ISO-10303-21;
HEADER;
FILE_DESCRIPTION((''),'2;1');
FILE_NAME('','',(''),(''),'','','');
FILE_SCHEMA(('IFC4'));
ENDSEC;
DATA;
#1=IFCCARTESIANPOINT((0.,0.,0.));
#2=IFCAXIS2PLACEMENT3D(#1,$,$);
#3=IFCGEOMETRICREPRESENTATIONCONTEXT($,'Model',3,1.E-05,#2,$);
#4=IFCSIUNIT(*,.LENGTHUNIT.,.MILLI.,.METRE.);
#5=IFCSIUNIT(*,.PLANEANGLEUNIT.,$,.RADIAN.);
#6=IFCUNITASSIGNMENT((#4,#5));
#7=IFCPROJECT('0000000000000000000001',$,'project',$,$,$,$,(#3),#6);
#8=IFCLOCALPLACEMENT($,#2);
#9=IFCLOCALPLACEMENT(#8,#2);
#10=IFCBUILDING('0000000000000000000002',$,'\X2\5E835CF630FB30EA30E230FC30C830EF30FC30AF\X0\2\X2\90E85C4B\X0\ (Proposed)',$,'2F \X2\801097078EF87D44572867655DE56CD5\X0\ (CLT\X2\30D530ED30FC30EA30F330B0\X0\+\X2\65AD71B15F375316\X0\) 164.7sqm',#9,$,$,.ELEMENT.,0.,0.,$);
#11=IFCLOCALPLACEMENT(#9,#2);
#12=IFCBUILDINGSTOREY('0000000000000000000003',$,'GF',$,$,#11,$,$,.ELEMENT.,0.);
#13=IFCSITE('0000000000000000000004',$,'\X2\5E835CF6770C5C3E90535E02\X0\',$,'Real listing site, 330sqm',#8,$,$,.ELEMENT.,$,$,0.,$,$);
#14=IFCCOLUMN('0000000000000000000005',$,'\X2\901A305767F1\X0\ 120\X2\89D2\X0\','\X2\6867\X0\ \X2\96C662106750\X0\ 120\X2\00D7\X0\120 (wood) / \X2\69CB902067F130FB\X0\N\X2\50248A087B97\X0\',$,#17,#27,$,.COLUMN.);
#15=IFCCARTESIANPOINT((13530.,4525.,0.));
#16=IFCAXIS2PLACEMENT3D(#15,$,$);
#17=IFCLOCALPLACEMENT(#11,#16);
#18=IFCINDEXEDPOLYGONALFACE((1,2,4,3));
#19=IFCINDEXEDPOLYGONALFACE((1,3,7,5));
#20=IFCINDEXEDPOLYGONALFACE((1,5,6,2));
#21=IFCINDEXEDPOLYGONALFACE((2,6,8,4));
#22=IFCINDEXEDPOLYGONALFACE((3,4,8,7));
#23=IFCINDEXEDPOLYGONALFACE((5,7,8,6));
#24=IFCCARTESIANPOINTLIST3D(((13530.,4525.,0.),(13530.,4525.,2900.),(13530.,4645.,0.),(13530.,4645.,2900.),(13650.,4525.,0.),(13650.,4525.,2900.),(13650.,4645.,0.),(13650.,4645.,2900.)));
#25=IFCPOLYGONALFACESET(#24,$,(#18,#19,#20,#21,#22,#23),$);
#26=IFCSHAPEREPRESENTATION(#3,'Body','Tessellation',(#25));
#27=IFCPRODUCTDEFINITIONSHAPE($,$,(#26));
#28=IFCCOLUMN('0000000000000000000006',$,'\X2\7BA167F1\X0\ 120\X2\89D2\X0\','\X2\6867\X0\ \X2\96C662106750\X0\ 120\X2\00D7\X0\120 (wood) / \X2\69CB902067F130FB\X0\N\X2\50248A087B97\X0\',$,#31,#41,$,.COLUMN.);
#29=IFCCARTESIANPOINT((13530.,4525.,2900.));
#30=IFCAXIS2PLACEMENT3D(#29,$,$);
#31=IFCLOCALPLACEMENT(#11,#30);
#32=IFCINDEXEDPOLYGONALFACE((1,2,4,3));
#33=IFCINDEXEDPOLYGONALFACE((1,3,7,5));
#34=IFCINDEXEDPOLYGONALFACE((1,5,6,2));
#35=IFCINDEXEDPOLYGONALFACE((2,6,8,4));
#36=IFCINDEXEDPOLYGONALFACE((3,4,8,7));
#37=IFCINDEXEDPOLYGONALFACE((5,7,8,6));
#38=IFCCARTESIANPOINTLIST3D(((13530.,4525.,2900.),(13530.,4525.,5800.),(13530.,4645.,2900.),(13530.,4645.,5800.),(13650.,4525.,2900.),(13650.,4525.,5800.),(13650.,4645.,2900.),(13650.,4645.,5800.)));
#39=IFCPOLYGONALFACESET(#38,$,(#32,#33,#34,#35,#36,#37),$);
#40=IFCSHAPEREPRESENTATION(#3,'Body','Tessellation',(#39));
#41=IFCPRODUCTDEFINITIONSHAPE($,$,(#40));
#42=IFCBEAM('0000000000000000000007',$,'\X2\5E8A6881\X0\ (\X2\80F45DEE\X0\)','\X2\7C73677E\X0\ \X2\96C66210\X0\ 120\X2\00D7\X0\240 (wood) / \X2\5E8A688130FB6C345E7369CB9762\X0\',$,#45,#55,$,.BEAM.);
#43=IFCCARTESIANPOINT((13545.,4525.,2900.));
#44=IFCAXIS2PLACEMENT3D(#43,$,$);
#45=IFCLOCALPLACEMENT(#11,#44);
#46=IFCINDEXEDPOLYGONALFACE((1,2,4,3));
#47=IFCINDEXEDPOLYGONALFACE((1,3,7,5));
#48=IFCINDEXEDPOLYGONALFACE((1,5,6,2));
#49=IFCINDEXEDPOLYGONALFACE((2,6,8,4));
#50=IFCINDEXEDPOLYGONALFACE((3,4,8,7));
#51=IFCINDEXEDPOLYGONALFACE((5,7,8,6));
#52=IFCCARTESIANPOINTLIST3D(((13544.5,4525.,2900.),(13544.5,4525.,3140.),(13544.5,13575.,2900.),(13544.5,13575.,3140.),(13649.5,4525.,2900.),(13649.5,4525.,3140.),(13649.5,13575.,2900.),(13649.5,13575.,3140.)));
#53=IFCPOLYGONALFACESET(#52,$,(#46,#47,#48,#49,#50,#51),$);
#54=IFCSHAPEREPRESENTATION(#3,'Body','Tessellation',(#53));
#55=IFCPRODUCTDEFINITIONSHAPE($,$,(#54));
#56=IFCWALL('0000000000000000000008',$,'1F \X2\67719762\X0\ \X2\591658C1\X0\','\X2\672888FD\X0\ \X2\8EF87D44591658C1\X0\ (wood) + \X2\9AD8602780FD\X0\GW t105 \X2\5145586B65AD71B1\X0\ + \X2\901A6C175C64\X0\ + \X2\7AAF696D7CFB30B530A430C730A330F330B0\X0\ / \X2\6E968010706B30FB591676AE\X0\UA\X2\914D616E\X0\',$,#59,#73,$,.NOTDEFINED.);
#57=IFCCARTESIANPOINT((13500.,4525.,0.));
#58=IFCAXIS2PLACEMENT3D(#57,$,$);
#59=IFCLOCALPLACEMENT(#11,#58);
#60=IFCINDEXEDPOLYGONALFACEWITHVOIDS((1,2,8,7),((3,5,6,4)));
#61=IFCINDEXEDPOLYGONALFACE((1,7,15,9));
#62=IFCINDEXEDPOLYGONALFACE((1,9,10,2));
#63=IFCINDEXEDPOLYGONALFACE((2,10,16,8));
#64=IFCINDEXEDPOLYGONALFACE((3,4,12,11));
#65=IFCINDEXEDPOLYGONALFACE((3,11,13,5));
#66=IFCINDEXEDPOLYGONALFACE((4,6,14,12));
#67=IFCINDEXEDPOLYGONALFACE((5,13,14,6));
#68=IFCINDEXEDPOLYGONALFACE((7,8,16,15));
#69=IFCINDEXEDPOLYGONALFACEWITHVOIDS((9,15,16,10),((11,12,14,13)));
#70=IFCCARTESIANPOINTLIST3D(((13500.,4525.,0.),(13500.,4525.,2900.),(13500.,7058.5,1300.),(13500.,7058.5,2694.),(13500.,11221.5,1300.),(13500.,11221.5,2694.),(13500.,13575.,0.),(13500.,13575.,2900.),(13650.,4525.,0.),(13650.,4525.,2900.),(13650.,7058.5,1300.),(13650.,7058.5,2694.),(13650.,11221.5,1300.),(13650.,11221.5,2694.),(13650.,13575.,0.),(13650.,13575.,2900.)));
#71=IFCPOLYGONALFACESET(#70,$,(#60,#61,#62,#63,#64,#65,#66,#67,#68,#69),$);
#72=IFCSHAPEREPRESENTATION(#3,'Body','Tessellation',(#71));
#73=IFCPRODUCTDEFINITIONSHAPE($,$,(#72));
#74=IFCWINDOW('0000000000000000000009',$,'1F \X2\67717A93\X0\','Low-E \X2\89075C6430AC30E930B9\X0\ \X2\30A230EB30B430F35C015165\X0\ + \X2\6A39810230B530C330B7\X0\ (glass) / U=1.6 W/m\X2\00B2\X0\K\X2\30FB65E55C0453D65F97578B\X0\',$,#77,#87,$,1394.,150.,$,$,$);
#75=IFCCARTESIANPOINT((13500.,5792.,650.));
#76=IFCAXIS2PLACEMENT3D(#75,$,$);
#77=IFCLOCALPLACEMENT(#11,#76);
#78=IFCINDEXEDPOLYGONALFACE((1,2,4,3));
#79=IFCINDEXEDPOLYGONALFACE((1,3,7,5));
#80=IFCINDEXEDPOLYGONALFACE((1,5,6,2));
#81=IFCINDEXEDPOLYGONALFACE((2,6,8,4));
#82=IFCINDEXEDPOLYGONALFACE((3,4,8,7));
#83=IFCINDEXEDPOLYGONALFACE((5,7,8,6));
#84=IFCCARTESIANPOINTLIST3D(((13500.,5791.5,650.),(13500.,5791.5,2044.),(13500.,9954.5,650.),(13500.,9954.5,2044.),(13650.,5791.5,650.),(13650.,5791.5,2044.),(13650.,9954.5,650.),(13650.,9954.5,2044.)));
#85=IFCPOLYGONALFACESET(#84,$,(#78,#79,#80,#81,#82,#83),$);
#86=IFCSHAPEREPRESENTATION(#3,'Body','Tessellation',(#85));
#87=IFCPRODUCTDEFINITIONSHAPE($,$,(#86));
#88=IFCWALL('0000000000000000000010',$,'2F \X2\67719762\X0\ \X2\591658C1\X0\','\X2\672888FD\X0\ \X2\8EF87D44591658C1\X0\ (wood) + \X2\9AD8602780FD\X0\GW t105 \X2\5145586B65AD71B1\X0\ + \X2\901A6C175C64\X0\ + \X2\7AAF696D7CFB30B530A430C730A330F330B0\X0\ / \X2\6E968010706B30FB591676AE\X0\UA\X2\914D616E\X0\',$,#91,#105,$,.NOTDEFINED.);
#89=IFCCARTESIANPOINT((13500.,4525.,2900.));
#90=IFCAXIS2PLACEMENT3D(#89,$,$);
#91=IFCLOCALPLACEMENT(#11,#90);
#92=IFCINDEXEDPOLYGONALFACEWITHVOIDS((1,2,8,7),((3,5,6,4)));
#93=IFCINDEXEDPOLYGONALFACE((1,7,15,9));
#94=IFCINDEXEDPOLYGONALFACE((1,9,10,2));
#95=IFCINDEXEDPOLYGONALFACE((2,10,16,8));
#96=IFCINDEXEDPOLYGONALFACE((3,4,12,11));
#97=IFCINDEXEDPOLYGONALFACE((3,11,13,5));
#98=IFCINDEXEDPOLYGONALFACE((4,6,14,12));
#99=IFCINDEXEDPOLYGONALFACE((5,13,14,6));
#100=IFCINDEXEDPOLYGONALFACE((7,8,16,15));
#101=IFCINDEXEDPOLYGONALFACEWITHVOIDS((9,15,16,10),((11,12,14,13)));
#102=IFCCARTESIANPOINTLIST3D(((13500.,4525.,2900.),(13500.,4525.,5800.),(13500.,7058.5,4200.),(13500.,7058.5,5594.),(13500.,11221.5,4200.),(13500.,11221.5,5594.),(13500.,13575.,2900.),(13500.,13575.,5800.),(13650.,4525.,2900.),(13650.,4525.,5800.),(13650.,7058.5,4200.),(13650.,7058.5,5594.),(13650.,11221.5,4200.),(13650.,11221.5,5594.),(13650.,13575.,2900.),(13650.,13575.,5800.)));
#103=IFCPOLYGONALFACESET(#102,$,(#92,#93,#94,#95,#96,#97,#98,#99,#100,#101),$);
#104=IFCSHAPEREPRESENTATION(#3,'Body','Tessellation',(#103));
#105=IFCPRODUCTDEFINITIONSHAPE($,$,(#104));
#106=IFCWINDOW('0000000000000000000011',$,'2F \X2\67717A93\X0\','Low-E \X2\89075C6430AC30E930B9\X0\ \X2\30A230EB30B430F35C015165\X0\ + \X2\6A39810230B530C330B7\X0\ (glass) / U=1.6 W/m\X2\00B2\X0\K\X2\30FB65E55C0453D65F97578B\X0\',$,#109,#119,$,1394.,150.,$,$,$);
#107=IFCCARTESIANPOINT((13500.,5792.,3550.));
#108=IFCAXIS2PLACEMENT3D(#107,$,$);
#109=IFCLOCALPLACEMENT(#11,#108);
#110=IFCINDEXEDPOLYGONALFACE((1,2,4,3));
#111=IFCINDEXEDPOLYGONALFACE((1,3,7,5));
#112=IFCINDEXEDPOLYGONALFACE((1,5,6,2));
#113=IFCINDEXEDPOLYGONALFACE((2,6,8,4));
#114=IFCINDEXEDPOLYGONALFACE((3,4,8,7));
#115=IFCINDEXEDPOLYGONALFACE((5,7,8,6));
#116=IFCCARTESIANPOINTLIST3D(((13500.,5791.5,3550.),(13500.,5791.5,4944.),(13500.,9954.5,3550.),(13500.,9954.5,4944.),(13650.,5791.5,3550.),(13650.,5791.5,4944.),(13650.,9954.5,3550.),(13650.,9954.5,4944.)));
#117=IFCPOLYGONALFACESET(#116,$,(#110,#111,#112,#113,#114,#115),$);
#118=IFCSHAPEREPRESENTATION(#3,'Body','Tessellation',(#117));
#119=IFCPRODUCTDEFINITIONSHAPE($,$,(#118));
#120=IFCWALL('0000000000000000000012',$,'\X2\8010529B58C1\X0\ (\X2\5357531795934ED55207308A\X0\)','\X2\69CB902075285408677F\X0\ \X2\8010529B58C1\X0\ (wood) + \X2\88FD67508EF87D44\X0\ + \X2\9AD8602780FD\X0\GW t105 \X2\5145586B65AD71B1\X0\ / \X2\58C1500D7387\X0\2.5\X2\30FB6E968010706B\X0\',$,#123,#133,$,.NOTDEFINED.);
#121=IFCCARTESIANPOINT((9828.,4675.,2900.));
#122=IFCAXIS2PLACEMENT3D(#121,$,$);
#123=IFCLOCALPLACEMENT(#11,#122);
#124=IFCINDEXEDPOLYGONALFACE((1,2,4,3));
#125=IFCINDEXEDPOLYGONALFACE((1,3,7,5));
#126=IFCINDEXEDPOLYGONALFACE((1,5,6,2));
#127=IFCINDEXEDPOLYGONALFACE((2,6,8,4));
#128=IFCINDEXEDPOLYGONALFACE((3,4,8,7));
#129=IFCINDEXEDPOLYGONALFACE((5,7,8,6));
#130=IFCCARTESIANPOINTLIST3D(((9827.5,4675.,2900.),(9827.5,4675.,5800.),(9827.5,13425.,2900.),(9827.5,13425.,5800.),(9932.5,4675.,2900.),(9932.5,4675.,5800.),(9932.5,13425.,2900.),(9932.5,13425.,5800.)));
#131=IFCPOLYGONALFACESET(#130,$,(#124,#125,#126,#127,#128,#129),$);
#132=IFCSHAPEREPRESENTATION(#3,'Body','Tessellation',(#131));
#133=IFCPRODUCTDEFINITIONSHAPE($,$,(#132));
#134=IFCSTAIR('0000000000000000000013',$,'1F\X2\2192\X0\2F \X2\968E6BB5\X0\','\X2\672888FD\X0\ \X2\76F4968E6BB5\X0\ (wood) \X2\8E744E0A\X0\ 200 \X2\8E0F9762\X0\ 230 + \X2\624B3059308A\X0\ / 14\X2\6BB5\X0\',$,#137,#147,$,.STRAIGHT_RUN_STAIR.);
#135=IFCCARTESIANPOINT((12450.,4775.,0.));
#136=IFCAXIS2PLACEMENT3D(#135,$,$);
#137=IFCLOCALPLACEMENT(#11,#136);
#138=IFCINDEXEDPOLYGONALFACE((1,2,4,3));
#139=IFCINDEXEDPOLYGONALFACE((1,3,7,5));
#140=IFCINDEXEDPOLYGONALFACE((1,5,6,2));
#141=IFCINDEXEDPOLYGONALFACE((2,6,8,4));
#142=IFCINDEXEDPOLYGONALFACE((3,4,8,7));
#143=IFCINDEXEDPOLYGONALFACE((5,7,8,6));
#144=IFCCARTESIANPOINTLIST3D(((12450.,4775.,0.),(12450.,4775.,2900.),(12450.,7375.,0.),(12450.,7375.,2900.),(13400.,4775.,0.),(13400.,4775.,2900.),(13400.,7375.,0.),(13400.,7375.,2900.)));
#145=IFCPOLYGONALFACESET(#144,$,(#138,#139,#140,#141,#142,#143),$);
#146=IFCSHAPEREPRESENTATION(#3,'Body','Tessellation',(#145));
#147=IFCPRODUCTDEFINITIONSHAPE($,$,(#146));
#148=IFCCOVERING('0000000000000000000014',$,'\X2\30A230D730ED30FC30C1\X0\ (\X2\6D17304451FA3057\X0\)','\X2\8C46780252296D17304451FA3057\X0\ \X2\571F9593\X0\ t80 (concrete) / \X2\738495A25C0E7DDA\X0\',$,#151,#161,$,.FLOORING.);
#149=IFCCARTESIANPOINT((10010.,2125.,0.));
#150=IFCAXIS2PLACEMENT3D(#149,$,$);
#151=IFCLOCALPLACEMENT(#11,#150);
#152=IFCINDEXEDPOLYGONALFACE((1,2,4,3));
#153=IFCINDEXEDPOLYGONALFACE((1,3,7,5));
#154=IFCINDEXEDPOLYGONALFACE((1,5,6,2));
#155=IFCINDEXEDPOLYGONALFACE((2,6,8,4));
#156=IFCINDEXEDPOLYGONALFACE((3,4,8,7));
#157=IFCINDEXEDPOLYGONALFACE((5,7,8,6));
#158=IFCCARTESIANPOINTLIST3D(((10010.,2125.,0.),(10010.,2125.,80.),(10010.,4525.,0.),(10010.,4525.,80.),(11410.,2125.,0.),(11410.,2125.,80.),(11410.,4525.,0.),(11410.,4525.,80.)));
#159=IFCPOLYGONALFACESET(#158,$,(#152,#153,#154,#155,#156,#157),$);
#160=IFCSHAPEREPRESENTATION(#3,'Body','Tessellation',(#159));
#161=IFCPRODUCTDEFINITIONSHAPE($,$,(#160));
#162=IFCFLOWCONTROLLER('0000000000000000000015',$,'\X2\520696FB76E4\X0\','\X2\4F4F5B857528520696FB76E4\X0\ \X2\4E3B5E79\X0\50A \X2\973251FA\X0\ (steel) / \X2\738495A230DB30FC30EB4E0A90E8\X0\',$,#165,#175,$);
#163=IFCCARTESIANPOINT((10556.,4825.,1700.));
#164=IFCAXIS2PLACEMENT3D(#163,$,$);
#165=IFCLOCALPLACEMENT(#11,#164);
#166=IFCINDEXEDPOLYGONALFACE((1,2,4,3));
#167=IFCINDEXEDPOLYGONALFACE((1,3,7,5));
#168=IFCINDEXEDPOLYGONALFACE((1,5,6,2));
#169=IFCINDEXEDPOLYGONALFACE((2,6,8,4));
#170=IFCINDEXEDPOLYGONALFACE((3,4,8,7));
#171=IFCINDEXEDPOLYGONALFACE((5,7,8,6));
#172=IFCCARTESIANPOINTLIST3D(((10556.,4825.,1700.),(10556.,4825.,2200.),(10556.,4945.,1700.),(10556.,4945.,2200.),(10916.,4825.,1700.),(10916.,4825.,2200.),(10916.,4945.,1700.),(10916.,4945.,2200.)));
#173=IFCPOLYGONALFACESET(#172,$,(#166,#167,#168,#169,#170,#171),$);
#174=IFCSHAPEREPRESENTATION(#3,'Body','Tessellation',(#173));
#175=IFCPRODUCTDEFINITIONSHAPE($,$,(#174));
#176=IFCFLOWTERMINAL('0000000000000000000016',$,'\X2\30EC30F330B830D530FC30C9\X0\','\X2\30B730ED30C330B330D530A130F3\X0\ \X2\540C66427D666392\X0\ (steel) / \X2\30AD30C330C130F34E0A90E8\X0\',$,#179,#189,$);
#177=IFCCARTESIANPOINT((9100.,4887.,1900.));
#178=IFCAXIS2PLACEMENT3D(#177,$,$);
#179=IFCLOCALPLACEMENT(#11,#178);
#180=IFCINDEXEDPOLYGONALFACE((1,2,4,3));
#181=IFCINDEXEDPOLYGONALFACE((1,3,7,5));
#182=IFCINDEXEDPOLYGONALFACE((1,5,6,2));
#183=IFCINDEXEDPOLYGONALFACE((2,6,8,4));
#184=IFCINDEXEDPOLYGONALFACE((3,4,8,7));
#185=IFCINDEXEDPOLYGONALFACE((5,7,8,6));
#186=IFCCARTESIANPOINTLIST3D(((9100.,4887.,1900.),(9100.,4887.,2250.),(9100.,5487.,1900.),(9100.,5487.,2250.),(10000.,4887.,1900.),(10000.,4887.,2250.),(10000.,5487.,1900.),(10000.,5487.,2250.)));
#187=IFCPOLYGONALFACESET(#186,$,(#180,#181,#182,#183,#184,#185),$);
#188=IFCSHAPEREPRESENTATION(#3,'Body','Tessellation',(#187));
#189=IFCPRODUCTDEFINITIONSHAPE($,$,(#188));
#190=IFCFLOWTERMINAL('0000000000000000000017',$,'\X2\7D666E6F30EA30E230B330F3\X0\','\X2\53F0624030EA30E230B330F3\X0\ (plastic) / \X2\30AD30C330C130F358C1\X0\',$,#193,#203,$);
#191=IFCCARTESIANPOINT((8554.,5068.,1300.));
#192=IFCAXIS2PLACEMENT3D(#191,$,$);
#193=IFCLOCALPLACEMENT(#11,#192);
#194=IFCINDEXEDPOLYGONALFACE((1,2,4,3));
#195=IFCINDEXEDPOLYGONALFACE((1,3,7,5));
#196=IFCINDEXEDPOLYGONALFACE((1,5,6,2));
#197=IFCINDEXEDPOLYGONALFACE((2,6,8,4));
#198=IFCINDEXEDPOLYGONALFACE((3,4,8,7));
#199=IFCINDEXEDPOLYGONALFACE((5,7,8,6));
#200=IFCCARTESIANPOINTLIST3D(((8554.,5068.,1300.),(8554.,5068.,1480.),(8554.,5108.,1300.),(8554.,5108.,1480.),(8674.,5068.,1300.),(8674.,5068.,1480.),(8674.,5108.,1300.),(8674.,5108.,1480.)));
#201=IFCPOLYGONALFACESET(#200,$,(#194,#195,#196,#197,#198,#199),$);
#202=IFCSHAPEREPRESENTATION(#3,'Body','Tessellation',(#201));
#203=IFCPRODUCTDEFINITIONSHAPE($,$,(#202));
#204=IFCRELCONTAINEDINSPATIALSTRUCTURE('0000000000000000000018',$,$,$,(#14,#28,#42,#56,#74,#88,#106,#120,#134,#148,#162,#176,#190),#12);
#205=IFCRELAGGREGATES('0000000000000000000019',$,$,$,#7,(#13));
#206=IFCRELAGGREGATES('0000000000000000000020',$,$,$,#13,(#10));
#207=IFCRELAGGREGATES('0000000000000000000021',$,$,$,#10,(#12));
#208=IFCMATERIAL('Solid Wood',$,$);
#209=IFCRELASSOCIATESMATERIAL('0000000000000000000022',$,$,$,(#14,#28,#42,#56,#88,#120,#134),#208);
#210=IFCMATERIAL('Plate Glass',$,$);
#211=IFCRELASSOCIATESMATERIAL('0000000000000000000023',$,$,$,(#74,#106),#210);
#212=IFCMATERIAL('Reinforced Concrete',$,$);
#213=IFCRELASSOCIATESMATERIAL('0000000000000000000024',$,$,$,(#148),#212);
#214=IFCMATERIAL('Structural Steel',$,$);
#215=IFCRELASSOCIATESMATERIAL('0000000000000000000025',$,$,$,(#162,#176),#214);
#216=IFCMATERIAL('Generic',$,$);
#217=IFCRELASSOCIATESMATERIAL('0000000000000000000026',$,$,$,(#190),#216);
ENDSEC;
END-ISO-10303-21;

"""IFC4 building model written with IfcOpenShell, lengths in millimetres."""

from ifc_helpers import new_model, si_unit, frame, frame_2d, origin, place, context, project, spatial, rectangle, extrude, material, element, fill, save


model = new_model("IFC4")

# Units and contexts
model_context = context("Model", 3, precision=1e-05, world=origin())
ifc_project = project(units=[si_unit("LENGTHUNIT", "METRE", prefix="MILLI"), si_unit("PLANEANGLEUNIT", "RADIAN")], contexts=[model_context])

# Site, building, storey
site_placement = place(None, origin())
site = spatial("IfcSite", under=ifc_project, at=site_placement, Name="広島県尾道市", ObjectType="Real listing site, 330sqm", CompositionType="ELEMENT", RefElevation=0.0)
building_placement = place(site_placement, origin())
building = spatial("IfcBuilding", under=site, at=building_placement, Name="広島・リモートワーク2部屋 (Proposed)", ObjectType="2F 耐震軸組在来工法 (CLTフローリング+断熱強化) 164.7sqm", CompositionType="ELEMENT", ElevationOfRefHeight=0.0, ElevationOfTerrain=0.0)
storey_placement = place(building_placement, origin())
storey = spatial("IfcBuildingStorey", under=building, at=storey_placement, Name="GF", CompositionType="ELEMENT", Elevation=0.0)

# Columns
ifc_material_1 = material(Name="Solid Wood")
column_1_placement = place(storey_placement, frame((13530.0, 4525.0, 0.0)))
element("IfcColumn", 1, at=column_1_placement, inside=storey, material=ifc_material_1, Name="通し柱 120角", Description="桧 集成材 120×120 (wood) / 構造柱・N値計算", PredefinedType="COLUMN", context=model_context, shape_type="SweptSolid", body=[
    extrude(rectangle(XDim=120.0, YDim=120.0, at=frame_2d((60.0, 60.0))), frame((13530.0, 4525.0, 0.0)), (0.0, 0.0, 1.0), 2900.0),
])
column_2_placement = place(storey_placement, frame((13530.0, 4525.0, 2900.0)))
element("IfcColumn", 2, at=column_2_placement, inside=storey, material=ifc_material_1, Name="管柱 120角", Description="桧 集成材 120×120 (wood) / 構造柱・N値計算", PredefinedType="COLUMN", context=model_context, shape_type="SweptSolid", body=[
    extrude(rectangle(XDim=120.0, YDim=120.0, at=frame_2d((60.0, 60.0))), frame((13530.0, 4525.0, 2900.0)), (0.0, 0.0, 1.0), 2900.0),
])

# Beam
beam_1_placement = place(storey_placement, frame((13545.0, 4525.0, 2900.0)))
element("IfcBeam", 3, at=beam_1_placement, inside=storey, material=ifc_material_1, Name="床梁 (胴差)", Description="米松 集成 120×240 (wood) / 床梁・水平構面", PredefinedType="BEAM", context=model_context, shape_type="SweptSolid", body=[
    extrude(rectangle(XDim=105.0, YDim=9050.0, at=frame_2d((52.0, 4525.0))), frame((13545.0, 4525.0, 2900.0)), (0.0, 0.0, 1.0), 240.0),
])

# Wall, opening, window
wall_1_placement = place(storey_placement, frame((13500.0, 4525.0, 0.0)))
wall_1 = element("IfcWall", 4, at=wall_1_placement, inside=storey, material=ifc_material_1, Name="1F 東面 外壁", Description="木製 軸組外壁 (wood) + 高性能GW t105 充填断熱 + 通気層 + 窯業系サイディング / 準耐火・外皮UA配慮", PredefinedType="NOTDEFINED", context=model_context, shape_type="SweptSolid", body=[
    extrude(rectangle(XDim=150.0, YDim=9050.0, at=frame_2d((75.0, 4525.0))), frame((13500.0, 4525.0, 0.0)), (0.0, 0.0, 1.0), 2900.0),
])
opening_1_placement = place(storey_placement, frame((13500.0, 5792.0, 650.0)))
opening_1 = element("IfcOpeningElement", 5, at=opening_1_placement, cuts=wall_1, PredefinedType="NOTDEFINED", context=model_context, shape_type="SweptSolid", body=[
    extrude(rectangle(XDim=150.0, YDim=4163.0, at=frame_2d((75.0, 2081.0))), frame((13500.0, 5792.0, 650.0)), (0.0, 0.0, 1.0), 1394.0),
])
ifc_material_2 = material(Name="Plate Glass")
window_1_placement = place(storey_placement, frame((13500.0, 5792.0, 650.0)))
window_1 = element("IfcWindow", 6, at=window_1_placement, inside=storey, material=ifc_material_2, Name="1F 東窓", Description="Low-E 複層ガラス アルゴン封入 + 樹脂サッシ (glass) / U=1.6 W/m²K・日射取得型", OverallHeight=1394.0, OverallWidth=150.0, context=model_context, shape_type="SweptSolid", body=[
    extrude(rectangle(XDim=150.0, YDim=4163.0, at=frame_2d((75.0, 2081.0))), frame((13500.0, 5792.0, 650.0)), (0.0, 0.0, 1.0), 1394.0),
])
fill(opening_1, window_1)

# Wall, opening, window
wall_2_placement = place(storey_placement, frame((13500.0, 4525.0, 2900.0)))
wall_2 = element("IfcWall", 7, at=wall_2_placement, inside=storey, material=ifc_material_1, Name="2F 東面 外壁", Description="木製 軸組外壁 (wood) + 高性能GW t105 充填断熱 + 通気層 + 窯業系サイディング / 準耐火・外皮UA配慮", PredefinedType="NOTDEFINED", context=model_context, shape_type="SweptSolid", body=[
    extrude(rectangle(XDim=150.0, YDim=9050.0, at=frame_2d((75.0, 4525.0))), frame((13500.0, 4525.0, 2900.0)), (0.0, 0.0, 1.0), 2900.0),
])
opening_2_placement = place(storey_placement, frame((13500.0, 5792.0, 3550.0)))
opening_2 = element("IfcOpeningElement", 8, at=opening_2_placement, cuts=wall_2, PredefinedType="NOTDEFINED", context=model_context, shape_type="SweptSolid", body=[
    extrude(rectangle(XDim=150.0, YDim=4163.0, at=frame_2d((75.0, 2081.0))), frame((13500.0, 5792.0, 3550.0)), (0.0, 0.0, 1.0), 1394.0),
])
window_2_placement = place(storey_placement, frame((13500.0, 5792.0, 3550.0)))
window_2 = element("IfcWindow", 9, at=window_2_placement, inside=storey, material=ifc_material_2, Name="2F 東窓", Description="Low-E 複層ガラス アルゴン封入 + 樹脂サッシ (glass) / U=1.6 W/m²K・日射取得型", OverallHeight=1394.0, OverallWidth=150.0, context=model_context, shape_type="SweptSolid", body=[
    extrude(rectangle(XDim=150.0, YDim=4163.0, at=frame_2d((75.0, 2081.0))), frame((13500.0, 5792.0, 3550.0)), (0.0, 0.0, 1.0), 1394.0),
])
fill(opening_2, window_2)

# Wall
wall_3_placement = place(storey_placement, frame((9828.0, 4675.0, 2900.0)))
element("IfcWall", 10, at=wall_3_placement, inside=storey, material=ifc_material_1, Name="耐力壁 (南北間仕切り)", Description="構造用合板 耐力壁 (wood) + 製材軸組 + 高性能GW t105 充填断熱 / 壁倍率2.5・準耐火", PredefinedType="NOTDEFINED", context=model_context, shape_type="SweptSolid", body=[
    extrude(rectangle(XDim=105.0, YDim=8750.0, at=frame_2d((52.0, 4375.0))), frame((9828.0, 4675.0, 2900.0)), (0.0, 0.0, 1.0), 2900.0),
])

# Stair
stair_placement = place(storey_placement, frame((12450.0, 4775.0, 0.0)))
element("IfcStair", 11, at=stair_placement, inside=storey, material=ifc_material_1, Name="1F→2F 階段", Description="木製 直階段 (wood) 蹴上 200 踏面 230 + 手すり / 14段", PredefinedType="STRAIGHT_RUN_STAIR", context=model_context, shape_type="SweptSolid", body=[
    extrude(rectangle(XDim=950.0, YDim=2600.0, at=frame_2d((475.0, 1300.0))), frame((12450.0, 4775.0, 0.0)), (0.0, 0.0, 1.0), 2900.0),
])

# Covering
ifc_material_3 = material(Name="Reinforced Concrete")
covering_placement = place(storey_placement, frame((10010.0, 2125.0, 0.0)))
element("IfcCovering", 12, at=covering_placement, inside=storey, material=ifc_material_3, Name="アプローチ (洗い出し)", Description="豆砂利洗い出し 土間 t80 (concrete) / 玄関導線", PredefinedType="FLOORING", context=model_context, shape_type="SweptSolid", body=[
    extrude(rectangle(XDim=1400.0, YDim=2400.0, at=frame_2d((700.0, 1200.0))), frame((10010.0, 2125.0, 0.0)), (0.0, 0.0, 1.0), 80.0),
])

# Flow controller
ifc_material_4 = material(Name="Structural Steel")
flow_controller_placement = place(storey_placement, frame((10556.0, 4825.0, 1700.0)))
element("IfcFlowController", 13, at=flow_controller_placement, inside=storey, material=ifc_material_4, Name="分電盤", Description="住宅用分電盤 主幹50A 露出 (steel) / 玄関ホール上部", context=model_context, shape_type="SweptSolid", body=[
    extrude(rectangle(XDim=360.0, YDim=120.0, at=frame_2d((180.0, 60.0))), frame((10556.0, 4825.0, 1700.0)), (0.0, 0.0, 1.0), 500.0),
])

# Flow terminals
flow_terminal_1_placement = place(storey_placement, frame((9100.0, 4887.0, 1900.0)))
element("IfcFlowTerminal", 14, at=flow_terminal_1_placement, inside=storey, material=ifc_material_4, Name="レンジフード", Description="シロッコファン 同時給排 (steel) / キッチン上部", context=model_context, shape_type="SweptSolid", body=[
    extrude(rectangle(XDim=900.0, YDim=600.0, at=frame_2d((450.0, 300.0))), frame((9100.0, 4887.0, 1900.0)), (0.0, 0.0, 1.0), 350.0),
])
ifc_material_5 = material(Name="Generic")
flow_terminal_2_placement = place(storey_placement, frame((8554.0, 5068.0, 1300.0)))
element("IfcFlowTerminal", 15, at=flow_terminal_2_placement, inside=storey, material=ifc_material_5, Name="給湯リモコン", Description="台所リモコン (plastic) / キッチン壁", context=model_context, shape_type="SweptSolid", body=[
    extrude(rectangle(XDim=120.0, YDim=40.0, at=frame_2d((60.0, 20.0))), frame((8554.0, 5068.0, 1300.0)), (0.0, 0.0, 1.0), 180.0),
])

save(model, "model.ifc")
